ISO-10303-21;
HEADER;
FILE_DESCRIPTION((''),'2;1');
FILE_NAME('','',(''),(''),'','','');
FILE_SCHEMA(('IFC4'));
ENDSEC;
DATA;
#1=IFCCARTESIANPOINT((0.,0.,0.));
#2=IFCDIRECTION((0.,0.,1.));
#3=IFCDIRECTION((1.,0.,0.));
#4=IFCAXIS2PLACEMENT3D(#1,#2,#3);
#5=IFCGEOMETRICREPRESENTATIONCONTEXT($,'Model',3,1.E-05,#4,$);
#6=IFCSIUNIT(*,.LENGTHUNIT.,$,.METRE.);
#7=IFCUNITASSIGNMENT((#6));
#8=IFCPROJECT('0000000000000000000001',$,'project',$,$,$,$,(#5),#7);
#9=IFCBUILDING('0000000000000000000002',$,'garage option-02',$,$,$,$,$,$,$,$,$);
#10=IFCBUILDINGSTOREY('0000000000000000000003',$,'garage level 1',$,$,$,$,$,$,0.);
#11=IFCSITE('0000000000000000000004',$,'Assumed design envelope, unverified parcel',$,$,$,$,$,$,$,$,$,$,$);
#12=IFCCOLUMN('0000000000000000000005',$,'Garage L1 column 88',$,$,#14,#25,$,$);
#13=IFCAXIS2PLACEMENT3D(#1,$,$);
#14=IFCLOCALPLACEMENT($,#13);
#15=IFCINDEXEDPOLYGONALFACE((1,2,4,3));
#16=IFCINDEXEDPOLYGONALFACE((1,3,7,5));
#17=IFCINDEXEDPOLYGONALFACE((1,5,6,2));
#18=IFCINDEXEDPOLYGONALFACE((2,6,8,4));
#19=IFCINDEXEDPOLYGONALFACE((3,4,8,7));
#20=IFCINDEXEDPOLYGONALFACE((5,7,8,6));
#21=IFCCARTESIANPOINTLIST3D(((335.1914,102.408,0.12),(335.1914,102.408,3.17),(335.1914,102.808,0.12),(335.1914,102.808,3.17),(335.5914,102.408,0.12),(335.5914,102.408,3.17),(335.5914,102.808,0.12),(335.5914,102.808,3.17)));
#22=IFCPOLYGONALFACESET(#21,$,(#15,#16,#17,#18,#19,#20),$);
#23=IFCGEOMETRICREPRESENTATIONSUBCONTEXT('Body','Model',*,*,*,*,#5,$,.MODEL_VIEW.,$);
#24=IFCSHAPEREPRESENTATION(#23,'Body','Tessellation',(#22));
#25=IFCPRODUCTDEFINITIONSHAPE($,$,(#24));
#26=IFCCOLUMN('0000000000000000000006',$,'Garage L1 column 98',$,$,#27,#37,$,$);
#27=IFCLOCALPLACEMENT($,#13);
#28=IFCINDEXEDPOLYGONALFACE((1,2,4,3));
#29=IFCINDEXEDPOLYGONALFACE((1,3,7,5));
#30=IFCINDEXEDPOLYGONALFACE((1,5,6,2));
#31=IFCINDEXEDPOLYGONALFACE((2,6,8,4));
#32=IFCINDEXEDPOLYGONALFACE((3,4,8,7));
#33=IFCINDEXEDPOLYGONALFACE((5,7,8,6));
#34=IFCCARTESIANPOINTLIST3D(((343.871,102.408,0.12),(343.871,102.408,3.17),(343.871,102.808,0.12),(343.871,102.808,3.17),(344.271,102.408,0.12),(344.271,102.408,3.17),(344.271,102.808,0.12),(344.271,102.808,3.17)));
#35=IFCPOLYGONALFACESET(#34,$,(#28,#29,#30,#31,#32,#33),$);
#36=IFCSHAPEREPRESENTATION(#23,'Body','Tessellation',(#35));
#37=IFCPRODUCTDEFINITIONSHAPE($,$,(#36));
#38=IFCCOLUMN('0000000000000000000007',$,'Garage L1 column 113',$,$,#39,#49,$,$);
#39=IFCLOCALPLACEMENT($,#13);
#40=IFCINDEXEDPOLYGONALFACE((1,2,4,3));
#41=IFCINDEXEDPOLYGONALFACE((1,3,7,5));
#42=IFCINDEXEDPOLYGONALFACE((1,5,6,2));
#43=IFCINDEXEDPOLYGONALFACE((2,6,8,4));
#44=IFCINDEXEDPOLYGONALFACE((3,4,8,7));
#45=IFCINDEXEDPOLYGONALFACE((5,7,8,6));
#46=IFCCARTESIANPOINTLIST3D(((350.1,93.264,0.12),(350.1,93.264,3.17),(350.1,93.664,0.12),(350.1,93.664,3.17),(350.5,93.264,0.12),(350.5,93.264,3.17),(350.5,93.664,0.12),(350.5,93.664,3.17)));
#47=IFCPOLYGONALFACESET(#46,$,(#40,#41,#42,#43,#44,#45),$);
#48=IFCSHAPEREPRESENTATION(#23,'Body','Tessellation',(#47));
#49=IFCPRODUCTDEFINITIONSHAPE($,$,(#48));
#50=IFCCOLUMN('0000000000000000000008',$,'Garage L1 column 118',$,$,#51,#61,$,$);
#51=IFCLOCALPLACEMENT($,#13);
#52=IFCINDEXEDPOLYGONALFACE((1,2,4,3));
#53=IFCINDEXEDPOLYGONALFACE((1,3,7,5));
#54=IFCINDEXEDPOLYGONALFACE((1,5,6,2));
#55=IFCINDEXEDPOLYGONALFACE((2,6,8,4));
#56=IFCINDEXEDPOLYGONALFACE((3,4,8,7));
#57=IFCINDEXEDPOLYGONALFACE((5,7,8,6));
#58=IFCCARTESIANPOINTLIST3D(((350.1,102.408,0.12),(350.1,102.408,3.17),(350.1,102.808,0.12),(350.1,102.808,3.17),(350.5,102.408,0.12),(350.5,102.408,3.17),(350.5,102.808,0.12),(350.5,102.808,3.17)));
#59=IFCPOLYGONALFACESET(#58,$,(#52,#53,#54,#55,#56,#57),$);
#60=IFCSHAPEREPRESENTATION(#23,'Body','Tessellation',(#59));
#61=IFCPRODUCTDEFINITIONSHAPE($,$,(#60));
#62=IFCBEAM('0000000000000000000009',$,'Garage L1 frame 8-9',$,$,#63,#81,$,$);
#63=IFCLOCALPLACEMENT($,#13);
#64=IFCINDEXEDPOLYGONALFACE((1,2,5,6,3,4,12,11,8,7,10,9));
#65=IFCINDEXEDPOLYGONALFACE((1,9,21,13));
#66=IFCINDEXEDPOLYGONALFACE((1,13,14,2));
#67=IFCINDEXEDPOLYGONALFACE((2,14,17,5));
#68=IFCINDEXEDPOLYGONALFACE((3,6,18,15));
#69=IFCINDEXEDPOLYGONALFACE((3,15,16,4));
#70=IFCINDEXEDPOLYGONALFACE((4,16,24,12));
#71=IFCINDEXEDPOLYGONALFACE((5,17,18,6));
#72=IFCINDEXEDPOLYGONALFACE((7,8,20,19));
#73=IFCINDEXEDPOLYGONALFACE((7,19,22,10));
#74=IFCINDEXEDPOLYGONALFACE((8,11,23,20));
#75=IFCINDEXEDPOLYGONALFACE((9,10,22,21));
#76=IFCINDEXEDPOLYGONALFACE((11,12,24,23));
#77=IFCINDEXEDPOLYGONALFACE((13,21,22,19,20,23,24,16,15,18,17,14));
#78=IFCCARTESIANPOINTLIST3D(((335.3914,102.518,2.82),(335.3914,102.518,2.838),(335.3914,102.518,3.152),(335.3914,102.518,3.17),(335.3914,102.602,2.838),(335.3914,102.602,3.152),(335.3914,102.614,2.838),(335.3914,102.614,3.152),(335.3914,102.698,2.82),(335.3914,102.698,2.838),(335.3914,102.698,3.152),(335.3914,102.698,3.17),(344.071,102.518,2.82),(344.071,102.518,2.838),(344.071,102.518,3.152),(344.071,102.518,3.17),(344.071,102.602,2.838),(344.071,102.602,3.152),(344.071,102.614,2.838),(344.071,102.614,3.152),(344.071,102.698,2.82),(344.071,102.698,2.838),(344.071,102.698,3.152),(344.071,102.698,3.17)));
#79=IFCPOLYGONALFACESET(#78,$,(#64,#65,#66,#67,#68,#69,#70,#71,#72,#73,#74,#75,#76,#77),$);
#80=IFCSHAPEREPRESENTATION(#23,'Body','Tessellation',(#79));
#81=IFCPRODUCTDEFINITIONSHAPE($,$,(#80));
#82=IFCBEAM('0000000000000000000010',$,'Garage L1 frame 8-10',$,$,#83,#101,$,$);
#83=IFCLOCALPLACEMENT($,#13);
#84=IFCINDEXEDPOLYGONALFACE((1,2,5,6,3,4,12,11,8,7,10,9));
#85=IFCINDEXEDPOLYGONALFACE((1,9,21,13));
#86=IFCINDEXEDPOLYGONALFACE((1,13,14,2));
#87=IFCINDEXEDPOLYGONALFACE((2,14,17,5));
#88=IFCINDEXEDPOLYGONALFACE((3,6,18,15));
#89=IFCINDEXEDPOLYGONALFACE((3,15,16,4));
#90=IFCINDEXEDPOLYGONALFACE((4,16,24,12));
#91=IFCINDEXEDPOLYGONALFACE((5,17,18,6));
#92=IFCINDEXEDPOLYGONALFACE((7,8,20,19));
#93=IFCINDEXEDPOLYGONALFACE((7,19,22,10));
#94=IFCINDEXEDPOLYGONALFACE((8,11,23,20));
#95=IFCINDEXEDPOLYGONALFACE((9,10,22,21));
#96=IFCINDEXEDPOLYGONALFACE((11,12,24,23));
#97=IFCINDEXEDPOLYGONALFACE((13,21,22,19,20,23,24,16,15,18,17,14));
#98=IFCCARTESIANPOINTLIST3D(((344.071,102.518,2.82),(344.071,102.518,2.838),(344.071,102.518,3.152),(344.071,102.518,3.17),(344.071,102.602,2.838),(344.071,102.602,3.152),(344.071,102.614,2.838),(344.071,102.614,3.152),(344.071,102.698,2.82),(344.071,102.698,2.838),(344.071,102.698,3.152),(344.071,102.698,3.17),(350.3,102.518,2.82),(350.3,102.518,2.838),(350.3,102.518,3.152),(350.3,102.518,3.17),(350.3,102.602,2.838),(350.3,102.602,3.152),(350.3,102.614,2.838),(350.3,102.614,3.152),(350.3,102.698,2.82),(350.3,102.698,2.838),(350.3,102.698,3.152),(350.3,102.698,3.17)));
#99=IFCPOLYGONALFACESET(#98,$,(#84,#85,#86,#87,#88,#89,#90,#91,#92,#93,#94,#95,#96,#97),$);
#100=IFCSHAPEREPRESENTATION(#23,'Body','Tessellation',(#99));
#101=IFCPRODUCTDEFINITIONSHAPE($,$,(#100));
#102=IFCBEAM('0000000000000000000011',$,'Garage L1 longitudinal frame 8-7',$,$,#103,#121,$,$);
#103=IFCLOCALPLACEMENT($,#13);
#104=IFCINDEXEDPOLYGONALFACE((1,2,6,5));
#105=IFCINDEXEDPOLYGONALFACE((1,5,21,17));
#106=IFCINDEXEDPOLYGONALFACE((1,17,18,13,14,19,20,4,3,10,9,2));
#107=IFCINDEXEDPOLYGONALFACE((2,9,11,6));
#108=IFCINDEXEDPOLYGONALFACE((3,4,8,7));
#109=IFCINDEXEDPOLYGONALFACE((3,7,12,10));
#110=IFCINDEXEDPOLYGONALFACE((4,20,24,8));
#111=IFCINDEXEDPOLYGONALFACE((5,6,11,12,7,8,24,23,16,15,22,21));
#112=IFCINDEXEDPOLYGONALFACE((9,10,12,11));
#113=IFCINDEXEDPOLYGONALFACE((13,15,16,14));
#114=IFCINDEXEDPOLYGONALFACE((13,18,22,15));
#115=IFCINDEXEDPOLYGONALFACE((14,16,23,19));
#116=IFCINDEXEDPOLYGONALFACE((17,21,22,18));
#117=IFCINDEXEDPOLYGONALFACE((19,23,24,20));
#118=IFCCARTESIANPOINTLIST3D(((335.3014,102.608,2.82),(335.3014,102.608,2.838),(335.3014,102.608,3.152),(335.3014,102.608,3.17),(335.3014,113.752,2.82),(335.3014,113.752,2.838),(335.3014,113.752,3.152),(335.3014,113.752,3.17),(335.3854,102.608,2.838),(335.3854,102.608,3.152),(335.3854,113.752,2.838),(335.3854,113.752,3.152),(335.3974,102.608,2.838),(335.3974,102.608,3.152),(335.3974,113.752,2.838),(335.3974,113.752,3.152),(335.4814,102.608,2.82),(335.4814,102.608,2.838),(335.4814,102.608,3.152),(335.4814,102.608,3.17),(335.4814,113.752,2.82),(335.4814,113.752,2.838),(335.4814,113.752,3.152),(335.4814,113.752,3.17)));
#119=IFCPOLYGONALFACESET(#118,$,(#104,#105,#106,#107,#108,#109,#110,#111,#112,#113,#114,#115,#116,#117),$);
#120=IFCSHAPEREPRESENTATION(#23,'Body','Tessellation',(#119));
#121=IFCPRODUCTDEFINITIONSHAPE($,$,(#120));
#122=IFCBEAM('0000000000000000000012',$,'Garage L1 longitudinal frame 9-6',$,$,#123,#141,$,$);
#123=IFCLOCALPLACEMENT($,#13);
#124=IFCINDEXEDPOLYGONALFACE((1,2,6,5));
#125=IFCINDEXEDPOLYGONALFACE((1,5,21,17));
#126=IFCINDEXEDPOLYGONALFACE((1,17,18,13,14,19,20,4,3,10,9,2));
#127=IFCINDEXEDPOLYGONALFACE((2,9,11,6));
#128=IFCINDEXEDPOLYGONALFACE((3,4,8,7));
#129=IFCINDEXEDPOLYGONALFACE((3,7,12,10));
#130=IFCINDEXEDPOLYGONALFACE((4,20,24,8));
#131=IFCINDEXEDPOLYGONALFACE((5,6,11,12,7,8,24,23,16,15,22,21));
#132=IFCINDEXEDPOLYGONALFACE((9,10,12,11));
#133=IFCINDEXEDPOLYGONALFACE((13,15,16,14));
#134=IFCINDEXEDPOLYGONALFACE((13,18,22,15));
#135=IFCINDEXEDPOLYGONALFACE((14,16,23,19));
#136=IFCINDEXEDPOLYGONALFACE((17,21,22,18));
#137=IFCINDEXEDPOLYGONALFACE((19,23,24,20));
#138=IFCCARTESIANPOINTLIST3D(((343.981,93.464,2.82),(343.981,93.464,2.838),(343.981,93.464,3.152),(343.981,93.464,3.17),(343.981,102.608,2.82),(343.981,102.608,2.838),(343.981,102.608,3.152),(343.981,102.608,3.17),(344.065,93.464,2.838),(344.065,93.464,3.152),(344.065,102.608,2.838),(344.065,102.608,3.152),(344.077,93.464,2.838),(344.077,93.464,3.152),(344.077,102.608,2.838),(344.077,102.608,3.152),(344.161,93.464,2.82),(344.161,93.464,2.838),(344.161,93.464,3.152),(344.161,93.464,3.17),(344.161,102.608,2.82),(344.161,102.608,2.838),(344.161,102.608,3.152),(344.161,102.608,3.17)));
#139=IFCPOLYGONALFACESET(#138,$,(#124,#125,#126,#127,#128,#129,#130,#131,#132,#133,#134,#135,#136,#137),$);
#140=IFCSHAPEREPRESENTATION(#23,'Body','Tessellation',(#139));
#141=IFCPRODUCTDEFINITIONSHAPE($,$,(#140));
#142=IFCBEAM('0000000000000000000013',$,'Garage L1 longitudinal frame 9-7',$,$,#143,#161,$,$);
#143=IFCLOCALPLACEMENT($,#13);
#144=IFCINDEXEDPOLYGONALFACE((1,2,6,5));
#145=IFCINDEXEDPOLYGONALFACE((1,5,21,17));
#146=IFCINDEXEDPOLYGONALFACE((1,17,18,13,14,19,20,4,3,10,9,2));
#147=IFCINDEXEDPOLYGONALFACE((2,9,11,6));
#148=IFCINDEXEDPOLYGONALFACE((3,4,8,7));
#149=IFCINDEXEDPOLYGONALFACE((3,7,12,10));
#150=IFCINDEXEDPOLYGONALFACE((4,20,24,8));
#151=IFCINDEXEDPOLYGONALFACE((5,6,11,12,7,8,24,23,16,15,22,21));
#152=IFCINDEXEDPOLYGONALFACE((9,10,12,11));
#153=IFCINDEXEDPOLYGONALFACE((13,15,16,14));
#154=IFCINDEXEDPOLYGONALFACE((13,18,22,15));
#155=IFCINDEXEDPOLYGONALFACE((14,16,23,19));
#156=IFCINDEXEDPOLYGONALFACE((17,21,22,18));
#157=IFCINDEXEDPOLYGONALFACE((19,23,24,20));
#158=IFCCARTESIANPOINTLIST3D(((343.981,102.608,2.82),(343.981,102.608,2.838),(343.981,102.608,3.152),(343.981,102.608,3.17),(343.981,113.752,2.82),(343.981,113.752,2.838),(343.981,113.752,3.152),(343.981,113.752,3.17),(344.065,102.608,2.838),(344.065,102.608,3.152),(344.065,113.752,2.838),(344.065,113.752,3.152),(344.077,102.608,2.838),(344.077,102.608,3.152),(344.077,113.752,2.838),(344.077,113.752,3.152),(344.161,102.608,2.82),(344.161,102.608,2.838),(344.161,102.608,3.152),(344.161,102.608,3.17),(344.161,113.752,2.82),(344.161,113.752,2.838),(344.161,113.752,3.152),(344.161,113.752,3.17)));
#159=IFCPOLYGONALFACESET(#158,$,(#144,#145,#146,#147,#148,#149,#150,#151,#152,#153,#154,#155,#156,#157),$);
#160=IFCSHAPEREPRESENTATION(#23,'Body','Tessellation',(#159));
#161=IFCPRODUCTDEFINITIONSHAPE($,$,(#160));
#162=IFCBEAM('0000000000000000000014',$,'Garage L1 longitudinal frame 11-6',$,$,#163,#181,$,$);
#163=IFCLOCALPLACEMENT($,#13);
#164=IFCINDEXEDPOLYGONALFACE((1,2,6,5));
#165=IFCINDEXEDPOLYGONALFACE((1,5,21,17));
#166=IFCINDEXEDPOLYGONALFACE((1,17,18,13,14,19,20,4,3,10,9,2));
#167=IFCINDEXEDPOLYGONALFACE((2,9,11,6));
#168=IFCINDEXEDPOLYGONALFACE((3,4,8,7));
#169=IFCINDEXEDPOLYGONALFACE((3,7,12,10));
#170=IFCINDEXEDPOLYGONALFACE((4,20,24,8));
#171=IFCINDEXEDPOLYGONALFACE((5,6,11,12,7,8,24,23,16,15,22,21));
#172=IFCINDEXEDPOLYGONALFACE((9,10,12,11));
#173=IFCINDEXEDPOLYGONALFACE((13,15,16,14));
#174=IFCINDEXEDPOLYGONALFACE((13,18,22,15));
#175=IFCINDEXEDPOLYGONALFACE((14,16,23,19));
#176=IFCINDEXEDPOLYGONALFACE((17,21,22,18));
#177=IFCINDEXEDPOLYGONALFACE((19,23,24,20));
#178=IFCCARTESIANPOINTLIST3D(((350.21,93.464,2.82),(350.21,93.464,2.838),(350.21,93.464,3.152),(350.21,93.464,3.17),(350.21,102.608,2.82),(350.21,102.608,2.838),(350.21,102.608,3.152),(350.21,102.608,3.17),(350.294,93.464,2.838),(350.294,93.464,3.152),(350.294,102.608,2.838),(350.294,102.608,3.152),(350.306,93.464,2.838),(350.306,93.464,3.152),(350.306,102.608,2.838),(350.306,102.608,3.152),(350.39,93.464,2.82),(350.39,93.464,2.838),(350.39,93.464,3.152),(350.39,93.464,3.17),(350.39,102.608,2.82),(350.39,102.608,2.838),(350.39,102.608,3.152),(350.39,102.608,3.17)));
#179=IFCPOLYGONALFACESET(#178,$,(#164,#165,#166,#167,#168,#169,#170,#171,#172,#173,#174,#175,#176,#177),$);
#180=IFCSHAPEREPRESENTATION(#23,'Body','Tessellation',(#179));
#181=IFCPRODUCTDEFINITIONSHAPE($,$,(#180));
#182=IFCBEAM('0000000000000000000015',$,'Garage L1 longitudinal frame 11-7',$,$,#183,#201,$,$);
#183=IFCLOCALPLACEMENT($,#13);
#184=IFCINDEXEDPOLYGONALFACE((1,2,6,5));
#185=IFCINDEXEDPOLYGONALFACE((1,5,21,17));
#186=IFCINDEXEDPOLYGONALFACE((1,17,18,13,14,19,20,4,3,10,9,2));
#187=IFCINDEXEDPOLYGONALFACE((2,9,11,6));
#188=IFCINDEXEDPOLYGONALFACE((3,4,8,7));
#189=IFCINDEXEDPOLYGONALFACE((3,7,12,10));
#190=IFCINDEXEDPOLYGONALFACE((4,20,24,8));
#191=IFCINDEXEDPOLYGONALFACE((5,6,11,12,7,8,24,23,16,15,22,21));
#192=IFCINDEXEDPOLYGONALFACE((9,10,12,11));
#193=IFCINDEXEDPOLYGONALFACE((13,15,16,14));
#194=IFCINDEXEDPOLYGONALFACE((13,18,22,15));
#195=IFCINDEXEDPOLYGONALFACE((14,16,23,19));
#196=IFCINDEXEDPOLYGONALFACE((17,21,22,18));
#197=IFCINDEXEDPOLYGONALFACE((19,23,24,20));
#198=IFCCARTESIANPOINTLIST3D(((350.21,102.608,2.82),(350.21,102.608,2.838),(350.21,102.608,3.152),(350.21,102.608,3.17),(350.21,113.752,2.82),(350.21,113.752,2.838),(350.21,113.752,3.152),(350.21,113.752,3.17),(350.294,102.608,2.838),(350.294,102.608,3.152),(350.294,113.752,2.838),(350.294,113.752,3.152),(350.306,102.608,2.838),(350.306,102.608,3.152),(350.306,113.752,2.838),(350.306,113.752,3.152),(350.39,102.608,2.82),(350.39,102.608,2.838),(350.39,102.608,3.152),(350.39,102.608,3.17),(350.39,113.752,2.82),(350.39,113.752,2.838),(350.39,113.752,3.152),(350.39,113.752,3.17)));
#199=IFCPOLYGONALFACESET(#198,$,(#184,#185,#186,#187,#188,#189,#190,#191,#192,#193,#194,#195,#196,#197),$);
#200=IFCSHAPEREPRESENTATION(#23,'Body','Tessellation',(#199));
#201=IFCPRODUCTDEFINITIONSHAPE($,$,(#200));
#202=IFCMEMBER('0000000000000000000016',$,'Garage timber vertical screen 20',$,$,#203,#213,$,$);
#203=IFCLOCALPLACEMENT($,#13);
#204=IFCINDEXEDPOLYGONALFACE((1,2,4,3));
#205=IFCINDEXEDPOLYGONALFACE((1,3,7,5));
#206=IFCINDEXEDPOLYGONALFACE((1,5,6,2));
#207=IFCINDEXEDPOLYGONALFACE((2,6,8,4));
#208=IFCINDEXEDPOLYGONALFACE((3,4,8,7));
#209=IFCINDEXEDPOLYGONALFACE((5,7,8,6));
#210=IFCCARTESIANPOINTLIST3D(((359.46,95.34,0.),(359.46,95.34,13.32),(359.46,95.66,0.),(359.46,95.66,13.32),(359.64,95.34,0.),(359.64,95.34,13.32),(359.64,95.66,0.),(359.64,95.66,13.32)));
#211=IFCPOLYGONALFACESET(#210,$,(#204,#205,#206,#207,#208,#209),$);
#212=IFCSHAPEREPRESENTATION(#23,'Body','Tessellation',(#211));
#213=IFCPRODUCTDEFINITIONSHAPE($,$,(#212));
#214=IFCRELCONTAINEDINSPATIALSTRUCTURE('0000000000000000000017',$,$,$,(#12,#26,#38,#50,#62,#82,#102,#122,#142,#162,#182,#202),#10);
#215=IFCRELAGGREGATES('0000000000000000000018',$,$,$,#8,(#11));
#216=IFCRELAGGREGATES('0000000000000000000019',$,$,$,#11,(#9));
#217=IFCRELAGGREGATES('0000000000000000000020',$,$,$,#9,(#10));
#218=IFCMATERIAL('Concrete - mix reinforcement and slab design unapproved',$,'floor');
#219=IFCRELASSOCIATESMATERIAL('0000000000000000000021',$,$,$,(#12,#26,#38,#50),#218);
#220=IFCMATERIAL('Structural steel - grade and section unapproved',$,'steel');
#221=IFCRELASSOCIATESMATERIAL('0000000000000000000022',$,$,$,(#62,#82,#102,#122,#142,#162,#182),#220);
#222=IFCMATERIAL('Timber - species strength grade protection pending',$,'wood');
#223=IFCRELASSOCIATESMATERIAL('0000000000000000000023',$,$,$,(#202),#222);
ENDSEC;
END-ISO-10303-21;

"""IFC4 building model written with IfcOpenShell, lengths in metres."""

from ifc_helpers import new_model, si_unit, frame, origin_with_axes, place, context, subcontext, project, spatial, rectangle, i_section, extrude, material, element, save


model = new_model("IFC4")

# Units and contexts
model_context = context("Model", 3, precision=1e-05, world=origin_with_axes())
body_context = subcontext(model_context, "Body", "Model", "MODEL_VIEW")
ifc_project = project(units=[si_unit("LENGTHUNIT", "METRE")], contexts=[model_context])

# Site, building, storey
site = spatial("IfcSite", under=ifc_project, Name="Assumed design envelope, unverified parcel")
building = spatial("IfcBuilding", under=site, Name="garage option-02")
storey = spatial("IfcBuildingStorey", under=building, Name="garage level 1", Elevation=0.0)

# Columns
ifc_material_1 = material(Name="Concrete - mix reinforcement and slab design unapproved", Category="floor")
for number, where, z_axis, x_axis, name in (
    (1, (335.3914, 102.608, 0.12), (0.0, 0.0, 1.0), (1.0, 0.0, 0.0), "Garage L1 column 88"),
    (2, (344.071, 102.608, 0.12), (0.0, 0.0, 1.0), (1.0, 0.0, 0.0), "Garage L1 column 98"),
    (3, (350.3, 93.464, 0.12), (0.0, 0.0, 1.0), (1.0, 0.0, 0.0), "Garage L1 column 113"),
    (4, (350.3, 102.608, 0.12), (0.0, 0.0, 1.0), (1.0, 0.0, 0.0), "Garage L1 column 118"),
):
    element("IfcColumn", number, at=place(None, frame(where, z_axis=z_axis, x_axis=x_axis)), inside=storey, material=ifc_material_1, Name=name, context=body_context, shape_type="SweptSolid", body=[
        extrude(rectangle(XDim=0.4, YDim=0.4), origin_with_axes(), (0.0, 0.0, 1.0), 3.05),
    ])

# Beams
ifc_material_2 = material(Name="Structural steel - grade and section unapproved", Category="steel")
beam_1_placement = place(None, frame((335.3914, 102.608, 2.995), z_axis=(1.0, 0.0, 0.0), x_axis=(0.0, 1.0, 0.0)))
element("IfcBeam", 5, at=beam_1_placement, inside=storey, material=ifc_material_2, Name="Garage L1 frame 8-9", context=body_context, shape_type="SweptSolid", body=[
    extrude(i_section(OverallWidth=0.18, OverallDepth=0.35, WebThickness=0.012, FlangeThickness=0.018, FilletRadius=0.0), origin_with_axes(), (0.0, 0.0, 1.0), 8.6796),
])
beam_2_placement = place(None, frame((344.071, 102.608, 2.995), z_axis=(1.0, 0.0, 0.0), x_axis=(0.0, 1.0, 0.0)))
element("IfcBeam", 6, at=beam_2_placement, inside=storey, material=ifc_material_2, Name="Garage L1 frame 8-10", context=body_context, shape_type="SweptSolid", body=[
    extrude(i_section(OverallWidth=0.18, OverallDepth=0.35, WebThickness=0.012, FlangeThickness=0.018, FilletRadius=0.0), origin_with_axes(), (0.0, 0.0, 1.0), 6.229),
])
beam_3_placement = place(None, frame((335.3914, 102.608, 2.995), z_axis=(0.0, 1.0, 0.0), x_axis=(-1.0, 0.0, 0.0)))
element("IfcBeam", 7, at=beam_3_placement, inside=storey, material=ifc_material_2, Name="Garage L1 longitudinal frame 8-7", context=body_context, shape_type="SweptSolid", body=[
    extrude(i_section(OverallWidth=0.18, OverallDepth=0.35, WebThickness=0.012, FlangeThickness=0.018, FilletRadius=0.0), origin_with_axes(), (0.0, 0.0, 1.0), 11.144),
])
beam_4_placement = place(None, frame((344.071, 93.464, 2.995), z_axis=(0.0, 1.0, 0.0), x_axis=(-1.0, 0.0, 0.0)))
element("IfcBeam", 8, at=beam_4_placement, inside=storey, material=ifc_material_2, Name="Garage L1 longitudinal frame 9-6", context=body_context, shape_type="SweptSolid", body=[
    extrude(i_section(OverallWidth=0.18, OverallDepth=0.35, WebThickness=0.012, FlangeThickness=0.018, FilletRadius=0.0), origin_with_axes(), (0.0, 0.0, 1.0), 9.144),
])
beam_5_placement = place(None, frame((344.071, 102.608, 2.995), z_axis=(0.0, 1.0, 0.0), x_axis=(-1.0, 0.0, 0.0)))
element("IfcBeam", 9, at=beam_5_placement, inside=storey, material=ifc_material_2, Name="Garage L1 longitudinal frame 9-7", context=body_context, shape_type="SweptSolid", body=[
    extrude(i_section(OverallWidth=0.18, OverallDepth=0.35, WebThickness=0.012, FlangeThickness=0.018, FilletRadius=0.0), origin_with_axes(), (0.0, 0.0, 1.0), 11.144),
])
beam_6_placement = place(None, frame((350.3, 93.464, 2.995), z_axis=(0.0, 1.0, 0.0), x_axis=(-1.0, 0.0, 0.0)))
element("IfcBeam", 10, at=beam_6_placement, inside=storey, material=ifc_material_2, Name="Garage L1 longitudinal frame 11-6", context=body_context, shape_type="SweptSolid", body=[
    extrude(i_section(OverallWidth=0.18, OverallDepth=0.35, WebThickness=0.012, FlangeThickness=0.018, FilletRadius=0.0), origin_with_axes(), (0.0, 0.0, 1.0), 9.144),
])
beam_7_placement = place(None, frame((350.3, 102.608, 2.995), z_axis=(0.0, 1.0, 0.0), x_axis=(-1.0, 0.0, 0.0)))
element("IfcBeam", 11, at=beam_7_placement, inside=storey, material=ifc_material_2, Name="Garage L1 longitudinal frame 11-7", context=body_context, shape_type="SweptSolid", body=[
    extrude(i_section(OverallWidth=0.18, OverallDepth=0.35, WebThickness=0.012, FlangeThickness=0.018, FilletRadius=0.0), origin_with_axes(), (0.0, 0.0, 1.0), 11.144),
])

# Member
ifc_material_3 = material(Name="Timber - species strength grade protection pending", Category="wood")
for number, where, z_axis, x_axis, name in (
    (12, (359.55, 95.5, 0.0), (0.0, 0.0, 1.0), (1.0, 0.0, 0.0), "Garage timber vertical screen 20"),
):
    element("IfcMember", number, at=place(None, frame(where, z_axis=z_axis, x_axis=x_axis)), inside=storey, material=ifc_material_3, Name=name, context=body_context, shape_type="SweptSolid", body=[
        extrude(rectangle(XDim=0.18, YDim=0.32), origin_with_axes(), (0.0, 0.0, 1.0), 13.32),
    ])

save(model, "model.ifc")
